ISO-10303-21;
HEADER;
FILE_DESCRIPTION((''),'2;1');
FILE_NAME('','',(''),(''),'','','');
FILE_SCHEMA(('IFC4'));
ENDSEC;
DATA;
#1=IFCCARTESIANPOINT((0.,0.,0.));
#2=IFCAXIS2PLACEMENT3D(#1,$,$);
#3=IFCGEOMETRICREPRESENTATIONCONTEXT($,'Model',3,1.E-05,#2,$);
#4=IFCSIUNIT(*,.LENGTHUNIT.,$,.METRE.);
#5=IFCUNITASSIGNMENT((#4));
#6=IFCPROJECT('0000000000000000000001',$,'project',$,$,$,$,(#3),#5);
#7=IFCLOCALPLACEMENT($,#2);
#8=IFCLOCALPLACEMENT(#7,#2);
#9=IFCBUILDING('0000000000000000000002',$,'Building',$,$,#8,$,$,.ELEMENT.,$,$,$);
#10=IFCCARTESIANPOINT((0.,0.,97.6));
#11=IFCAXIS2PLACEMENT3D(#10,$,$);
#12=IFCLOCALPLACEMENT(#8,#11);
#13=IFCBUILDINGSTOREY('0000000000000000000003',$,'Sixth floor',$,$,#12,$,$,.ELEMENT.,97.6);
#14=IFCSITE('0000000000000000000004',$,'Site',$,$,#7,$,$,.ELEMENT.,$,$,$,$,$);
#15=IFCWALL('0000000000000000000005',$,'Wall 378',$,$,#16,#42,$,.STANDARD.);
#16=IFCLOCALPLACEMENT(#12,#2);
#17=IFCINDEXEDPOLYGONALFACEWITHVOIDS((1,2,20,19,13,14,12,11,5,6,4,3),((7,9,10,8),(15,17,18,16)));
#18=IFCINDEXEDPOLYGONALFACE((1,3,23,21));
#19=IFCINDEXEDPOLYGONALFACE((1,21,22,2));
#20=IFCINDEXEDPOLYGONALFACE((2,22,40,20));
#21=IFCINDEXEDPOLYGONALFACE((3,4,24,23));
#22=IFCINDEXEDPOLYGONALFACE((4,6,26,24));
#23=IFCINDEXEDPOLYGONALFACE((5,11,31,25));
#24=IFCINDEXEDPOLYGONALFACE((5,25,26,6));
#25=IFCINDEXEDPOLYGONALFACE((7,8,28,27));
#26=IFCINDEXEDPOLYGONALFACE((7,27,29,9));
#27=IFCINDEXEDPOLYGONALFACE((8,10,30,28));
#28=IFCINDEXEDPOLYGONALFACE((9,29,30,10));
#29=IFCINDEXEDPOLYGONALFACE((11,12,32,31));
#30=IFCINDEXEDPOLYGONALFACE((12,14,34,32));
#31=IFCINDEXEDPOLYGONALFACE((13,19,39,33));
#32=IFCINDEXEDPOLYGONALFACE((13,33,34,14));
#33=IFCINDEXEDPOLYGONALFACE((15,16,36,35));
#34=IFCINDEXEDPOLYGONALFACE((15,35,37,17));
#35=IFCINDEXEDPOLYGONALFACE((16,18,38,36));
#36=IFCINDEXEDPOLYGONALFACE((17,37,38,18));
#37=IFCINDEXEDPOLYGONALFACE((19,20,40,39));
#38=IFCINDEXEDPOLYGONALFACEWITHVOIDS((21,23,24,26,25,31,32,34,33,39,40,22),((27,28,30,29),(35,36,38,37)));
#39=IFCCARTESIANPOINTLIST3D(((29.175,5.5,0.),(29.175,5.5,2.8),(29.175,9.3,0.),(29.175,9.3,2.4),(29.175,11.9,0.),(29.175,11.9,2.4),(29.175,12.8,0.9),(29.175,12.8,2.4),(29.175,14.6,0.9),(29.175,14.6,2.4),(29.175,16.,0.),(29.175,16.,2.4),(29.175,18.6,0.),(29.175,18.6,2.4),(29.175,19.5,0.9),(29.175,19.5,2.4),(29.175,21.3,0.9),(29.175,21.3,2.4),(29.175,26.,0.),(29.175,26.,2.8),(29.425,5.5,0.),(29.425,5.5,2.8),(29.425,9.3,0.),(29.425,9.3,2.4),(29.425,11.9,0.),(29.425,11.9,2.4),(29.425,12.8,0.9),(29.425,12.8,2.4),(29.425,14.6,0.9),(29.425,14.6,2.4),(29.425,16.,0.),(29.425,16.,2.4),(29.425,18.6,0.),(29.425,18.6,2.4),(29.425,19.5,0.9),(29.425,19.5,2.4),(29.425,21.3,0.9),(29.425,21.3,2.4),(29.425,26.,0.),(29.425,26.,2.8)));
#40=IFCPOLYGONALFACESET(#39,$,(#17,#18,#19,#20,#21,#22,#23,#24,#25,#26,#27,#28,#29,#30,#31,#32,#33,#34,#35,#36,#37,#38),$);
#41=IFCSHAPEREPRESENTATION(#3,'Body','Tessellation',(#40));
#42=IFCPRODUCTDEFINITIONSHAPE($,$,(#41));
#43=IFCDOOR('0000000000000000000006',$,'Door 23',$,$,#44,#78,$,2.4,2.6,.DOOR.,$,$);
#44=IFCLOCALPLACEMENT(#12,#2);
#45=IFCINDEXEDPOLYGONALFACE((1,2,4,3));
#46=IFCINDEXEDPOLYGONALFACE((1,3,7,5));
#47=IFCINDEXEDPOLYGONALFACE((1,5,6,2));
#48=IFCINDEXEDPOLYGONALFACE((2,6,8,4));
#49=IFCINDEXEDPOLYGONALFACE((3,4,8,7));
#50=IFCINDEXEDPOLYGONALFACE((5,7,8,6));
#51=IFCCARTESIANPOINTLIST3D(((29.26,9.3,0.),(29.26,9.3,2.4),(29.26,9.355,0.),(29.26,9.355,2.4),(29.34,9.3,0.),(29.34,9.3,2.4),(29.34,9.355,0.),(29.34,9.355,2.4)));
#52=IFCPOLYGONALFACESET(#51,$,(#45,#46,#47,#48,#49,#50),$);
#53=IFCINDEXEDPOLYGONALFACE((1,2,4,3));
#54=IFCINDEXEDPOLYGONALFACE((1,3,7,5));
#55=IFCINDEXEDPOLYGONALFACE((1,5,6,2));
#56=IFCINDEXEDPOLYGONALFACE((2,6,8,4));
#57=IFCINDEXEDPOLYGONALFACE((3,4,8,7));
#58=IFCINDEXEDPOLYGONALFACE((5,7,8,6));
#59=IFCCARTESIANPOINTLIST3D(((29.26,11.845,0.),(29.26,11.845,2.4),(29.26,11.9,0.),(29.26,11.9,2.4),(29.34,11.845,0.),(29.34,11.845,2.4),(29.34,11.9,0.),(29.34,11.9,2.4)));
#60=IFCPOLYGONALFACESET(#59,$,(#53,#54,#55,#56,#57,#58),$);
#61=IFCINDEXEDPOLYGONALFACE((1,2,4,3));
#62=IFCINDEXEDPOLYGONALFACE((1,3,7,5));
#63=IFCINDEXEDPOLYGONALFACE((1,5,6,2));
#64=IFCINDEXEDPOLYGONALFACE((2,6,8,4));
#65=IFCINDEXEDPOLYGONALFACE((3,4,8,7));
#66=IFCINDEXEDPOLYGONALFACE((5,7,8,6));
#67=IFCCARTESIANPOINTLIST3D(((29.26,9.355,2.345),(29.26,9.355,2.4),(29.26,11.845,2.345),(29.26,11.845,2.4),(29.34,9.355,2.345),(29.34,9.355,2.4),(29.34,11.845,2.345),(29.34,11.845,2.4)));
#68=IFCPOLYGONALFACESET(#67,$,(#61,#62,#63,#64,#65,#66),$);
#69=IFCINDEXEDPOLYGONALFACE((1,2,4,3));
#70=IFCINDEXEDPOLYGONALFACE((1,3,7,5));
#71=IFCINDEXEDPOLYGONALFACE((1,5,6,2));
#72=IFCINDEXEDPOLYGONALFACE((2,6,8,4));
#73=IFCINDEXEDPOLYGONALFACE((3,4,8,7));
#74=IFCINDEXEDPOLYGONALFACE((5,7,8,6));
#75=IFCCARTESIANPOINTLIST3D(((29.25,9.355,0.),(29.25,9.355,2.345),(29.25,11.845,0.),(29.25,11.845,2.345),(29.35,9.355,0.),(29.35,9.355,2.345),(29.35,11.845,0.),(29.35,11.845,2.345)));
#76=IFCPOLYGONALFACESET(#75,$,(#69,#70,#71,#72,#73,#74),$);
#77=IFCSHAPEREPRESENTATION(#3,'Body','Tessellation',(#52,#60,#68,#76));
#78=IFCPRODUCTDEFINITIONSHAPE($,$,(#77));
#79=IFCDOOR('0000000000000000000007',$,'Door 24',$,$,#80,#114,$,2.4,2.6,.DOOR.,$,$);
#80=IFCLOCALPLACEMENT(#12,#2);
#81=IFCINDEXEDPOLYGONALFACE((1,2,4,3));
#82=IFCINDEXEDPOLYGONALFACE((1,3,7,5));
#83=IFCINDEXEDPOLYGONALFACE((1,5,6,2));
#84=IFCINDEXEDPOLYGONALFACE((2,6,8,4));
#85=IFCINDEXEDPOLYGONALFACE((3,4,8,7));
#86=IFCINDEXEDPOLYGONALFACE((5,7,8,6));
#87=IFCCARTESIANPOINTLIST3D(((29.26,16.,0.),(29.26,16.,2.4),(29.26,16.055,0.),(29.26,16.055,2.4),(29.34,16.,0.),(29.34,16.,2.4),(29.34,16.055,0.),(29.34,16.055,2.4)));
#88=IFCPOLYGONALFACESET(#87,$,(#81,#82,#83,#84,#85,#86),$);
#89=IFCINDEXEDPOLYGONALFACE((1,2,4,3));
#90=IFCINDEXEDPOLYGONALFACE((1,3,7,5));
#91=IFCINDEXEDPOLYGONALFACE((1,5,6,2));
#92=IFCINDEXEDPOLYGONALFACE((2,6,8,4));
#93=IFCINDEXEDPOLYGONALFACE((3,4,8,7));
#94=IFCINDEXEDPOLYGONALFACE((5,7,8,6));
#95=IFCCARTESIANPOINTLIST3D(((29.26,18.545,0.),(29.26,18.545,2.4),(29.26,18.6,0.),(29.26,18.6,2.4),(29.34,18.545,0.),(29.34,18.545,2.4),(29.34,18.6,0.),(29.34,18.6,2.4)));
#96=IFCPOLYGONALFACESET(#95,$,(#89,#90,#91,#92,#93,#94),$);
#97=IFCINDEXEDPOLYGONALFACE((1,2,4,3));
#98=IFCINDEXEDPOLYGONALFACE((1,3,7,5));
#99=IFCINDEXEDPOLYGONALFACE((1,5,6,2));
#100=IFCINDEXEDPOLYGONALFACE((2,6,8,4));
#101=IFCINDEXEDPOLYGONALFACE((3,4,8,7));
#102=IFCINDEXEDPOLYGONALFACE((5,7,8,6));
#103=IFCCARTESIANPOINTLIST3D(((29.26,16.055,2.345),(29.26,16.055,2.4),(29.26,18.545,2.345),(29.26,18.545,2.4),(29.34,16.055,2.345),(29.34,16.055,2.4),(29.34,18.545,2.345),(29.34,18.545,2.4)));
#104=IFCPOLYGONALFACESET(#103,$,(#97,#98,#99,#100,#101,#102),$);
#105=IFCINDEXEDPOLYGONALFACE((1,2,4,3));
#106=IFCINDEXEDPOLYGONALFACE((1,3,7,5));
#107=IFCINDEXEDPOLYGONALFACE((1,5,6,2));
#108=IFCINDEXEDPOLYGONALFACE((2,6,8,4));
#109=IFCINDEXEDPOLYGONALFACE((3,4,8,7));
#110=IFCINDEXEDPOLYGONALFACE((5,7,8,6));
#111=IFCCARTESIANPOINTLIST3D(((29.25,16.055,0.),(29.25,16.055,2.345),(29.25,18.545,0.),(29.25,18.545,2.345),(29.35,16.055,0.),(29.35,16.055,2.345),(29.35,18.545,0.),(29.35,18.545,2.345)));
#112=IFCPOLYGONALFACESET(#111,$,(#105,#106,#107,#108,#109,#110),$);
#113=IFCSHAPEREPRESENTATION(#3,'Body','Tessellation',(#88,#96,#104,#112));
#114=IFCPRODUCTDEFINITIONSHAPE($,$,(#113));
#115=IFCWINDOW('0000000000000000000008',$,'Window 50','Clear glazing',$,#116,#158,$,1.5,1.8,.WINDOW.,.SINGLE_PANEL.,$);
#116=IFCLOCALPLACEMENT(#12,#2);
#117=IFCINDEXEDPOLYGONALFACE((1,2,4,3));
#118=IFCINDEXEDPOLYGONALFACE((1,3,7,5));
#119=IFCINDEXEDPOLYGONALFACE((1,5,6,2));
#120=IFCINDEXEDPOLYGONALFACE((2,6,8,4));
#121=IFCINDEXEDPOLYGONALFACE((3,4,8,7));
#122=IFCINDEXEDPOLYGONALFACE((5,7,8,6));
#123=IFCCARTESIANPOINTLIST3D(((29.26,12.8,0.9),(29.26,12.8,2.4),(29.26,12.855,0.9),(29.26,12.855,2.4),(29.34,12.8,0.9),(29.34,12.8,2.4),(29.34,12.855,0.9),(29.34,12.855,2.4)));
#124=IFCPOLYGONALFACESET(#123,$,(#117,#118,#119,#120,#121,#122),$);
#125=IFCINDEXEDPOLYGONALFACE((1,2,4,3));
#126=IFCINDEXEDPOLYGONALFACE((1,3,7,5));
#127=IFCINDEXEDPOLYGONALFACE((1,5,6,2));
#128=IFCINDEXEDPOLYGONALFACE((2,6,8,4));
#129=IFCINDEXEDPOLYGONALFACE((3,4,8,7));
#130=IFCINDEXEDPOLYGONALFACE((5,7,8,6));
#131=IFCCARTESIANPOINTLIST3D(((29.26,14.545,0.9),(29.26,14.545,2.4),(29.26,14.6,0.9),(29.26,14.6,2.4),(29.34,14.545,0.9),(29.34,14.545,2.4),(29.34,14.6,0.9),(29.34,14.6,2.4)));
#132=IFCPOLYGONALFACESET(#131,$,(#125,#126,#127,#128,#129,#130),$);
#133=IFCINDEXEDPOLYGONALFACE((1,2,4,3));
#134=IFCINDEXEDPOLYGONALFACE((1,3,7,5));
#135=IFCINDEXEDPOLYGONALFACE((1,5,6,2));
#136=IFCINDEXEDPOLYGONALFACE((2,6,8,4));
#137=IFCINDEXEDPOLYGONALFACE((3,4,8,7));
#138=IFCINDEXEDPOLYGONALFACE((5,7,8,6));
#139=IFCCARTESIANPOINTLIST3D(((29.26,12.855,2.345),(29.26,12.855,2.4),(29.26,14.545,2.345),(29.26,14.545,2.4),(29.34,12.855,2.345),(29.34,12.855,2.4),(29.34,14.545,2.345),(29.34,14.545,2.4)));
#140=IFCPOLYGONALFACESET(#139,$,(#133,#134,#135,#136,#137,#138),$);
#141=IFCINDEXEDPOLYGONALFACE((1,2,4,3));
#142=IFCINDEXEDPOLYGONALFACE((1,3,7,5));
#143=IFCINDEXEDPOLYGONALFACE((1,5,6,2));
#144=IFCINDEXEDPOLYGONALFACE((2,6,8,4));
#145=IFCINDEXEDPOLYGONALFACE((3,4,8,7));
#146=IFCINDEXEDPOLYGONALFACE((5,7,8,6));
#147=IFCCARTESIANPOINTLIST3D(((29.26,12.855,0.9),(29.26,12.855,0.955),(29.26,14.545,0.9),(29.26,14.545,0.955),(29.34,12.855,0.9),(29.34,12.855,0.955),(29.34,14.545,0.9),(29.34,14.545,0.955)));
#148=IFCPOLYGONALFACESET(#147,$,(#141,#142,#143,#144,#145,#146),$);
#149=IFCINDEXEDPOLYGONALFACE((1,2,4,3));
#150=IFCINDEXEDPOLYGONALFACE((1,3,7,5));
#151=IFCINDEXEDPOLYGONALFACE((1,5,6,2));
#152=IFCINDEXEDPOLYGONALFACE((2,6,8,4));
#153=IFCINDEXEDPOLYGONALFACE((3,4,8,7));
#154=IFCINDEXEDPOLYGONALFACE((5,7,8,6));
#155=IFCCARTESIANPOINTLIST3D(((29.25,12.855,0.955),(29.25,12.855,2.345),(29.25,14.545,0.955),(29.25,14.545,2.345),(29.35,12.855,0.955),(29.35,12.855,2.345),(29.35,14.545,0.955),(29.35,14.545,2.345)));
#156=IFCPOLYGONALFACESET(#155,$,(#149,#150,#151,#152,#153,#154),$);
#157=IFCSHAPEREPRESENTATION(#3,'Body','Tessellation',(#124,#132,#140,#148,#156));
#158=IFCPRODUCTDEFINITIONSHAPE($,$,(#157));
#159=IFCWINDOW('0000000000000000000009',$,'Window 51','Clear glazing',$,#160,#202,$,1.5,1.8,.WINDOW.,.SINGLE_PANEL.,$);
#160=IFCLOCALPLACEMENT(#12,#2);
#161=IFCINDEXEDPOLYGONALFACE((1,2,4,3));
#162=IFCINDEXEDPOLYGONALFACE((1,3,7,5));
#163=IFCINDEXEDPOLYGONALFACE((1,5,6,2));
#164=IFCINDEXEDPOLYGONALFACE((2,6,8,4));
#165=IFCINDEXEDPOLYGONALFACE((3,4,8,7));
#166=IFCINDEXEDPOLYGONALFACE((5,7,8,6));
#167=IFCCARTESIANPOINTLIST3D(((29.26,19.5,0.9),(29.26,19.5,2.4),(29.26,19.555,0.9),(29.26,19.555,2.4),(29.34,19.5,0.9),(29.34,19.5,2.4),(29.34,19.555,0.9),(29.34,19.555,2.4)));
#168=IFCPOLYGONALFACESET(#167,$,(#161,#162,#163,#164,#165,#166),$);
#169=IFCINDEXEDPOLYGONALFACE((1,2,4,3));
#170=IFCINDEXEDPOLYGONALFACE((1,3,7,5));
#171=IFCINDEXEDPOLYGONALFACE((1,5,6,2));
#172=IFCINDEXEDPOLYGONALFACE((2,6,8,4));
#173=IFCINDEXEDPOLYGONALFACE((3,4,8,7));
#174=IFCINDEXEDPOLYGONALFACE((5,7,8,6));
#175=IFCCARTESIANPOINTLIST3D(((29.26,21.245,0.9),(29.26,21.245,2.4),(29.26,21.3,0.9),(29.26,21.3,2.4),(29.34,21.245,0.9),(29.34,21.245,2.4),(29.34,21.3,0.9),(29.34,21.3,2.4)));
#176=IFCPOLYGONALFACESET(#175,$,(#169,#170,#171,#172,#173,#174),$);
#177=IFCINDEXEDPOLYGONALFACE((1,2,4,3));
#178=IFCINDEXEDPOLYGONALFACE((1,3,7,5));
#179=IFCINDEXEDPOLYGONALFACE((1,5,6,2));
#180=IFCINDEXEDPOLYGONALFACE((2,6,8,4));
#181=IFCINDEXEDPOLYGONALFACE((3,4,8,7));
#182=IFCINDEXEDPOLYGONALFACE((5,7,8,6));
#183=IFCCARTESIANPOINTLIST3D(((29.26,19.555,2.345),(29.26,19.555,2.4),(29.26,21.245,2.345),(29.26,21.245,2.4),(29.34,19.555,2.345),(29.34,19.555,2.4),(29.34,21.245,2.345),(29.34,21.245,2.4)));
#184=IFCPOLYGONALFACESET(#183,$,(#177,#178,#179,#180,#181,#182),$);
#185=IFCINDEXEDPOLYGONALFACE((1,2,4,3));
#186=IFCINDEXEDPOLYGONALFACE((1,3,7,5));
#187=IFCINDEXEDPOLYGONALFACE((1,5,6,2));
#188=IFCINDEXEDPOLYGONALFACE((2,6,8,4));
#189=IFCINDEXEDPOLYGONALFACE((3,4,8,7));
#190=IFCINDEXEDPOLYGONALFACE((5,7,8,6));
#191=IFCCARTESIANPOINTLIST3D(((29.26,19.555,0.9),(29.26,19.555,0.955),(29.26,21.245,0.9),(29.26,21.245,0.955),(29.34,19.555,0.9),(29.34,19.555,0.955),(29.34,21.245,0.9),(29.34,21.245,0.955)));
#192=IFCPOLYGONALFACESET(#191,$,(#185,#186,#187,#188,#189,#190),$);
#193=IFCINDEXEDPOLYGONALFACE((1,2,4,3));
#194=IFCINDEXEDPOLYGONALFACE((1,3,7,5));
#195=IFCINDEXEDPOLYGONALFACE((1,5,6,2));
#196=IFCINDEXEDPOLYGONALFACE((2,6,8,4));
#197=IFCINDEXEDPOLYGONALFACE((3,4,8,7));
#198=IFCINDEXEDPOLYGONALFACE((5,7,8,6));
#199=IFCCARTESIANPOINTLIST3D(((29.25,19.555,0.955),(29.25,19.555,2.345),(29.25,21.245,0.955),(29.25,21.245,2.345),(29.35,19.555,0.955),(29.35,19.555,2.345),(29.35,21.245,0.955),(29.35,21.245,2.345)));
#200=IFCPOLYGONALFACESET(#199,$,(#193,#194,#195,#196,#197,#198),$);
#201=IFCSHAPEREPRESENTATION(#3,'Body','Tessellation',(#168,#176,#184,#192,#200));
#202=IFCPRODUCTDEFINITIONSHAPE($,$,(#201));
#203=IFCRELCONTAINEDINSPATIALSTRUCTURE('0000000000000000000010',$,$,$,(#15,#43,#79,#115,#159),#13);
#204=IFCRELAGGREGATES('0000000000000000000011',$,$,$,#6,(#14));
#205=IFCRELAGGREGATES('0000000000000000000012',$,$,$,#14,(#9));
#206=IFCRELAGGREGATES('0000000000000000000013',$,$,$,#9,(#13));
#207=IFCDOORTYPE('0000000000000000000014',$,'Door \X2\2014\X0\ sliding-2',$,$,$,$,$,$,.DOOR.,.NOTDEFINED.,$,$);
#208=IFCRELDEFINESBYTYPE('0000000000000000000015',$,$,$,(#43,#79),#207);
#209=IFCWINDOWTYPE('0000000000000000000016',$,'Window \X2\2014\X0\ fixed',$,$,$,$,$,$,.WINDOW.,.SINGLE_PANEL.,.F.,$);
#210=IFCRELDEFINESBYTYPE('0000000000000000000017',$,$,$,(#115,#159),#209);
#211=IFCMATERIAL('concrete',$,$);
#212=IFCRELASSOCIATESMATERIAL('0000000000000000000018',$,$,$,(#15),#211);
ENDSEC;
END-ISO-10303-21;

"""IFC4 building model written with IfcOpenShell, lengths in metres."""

from ifc_helpers import new_model, si_unit, frame, frame_2d, origin, place, context, project, spatial, rectangle, extrude, material, type_object, element, fill, save


model = new_model("IFC4")

# Units and contexts
model_context = context("Model", 3, precision=1e-05, world=origin())
ifc_project = project(units=[si_unit("LENGTHUNIT", "METRE")], contexts=[model_context])

# Site, building, storey
site_placement = place(None, origin())
site = spatial("IfcSite", under=ifc_project, at=site_placement, Name="Site", CompositionType="ELEMENT")
building_placement = place(site_placement, origin())
building = spatial("IfcBuilding", under=site, at=building_placement, Name="Building", CompositionType="ELEMENT")
storey_placement = place(building_placement, frame((0.0, 0.0, 97.6)))
storey = spatial("IfcBuildingStorey", under=building, at=storey_placement, Name="Sixth floor", CompositionType="ELEMENT", Elevation=97.6)

# Shared definitions
ifc_material = material(Name="concrete")

# Wall, openings, doors, windows
wall_1_placement = place(storey_placement, frame((29.3, 5.5, 0.0), z_axis=(0.0, 0.0, 1.0), x_axis=(0.0, 1.0, 0.0)))
wall_1 = element("IfcWall", 1, at=wall_1_placement, inside=storey, material=ifc_material, Name="Wall 378", PredefinedType="STANDARD", context=model_context, shape_type="SweptSolid", body=[
    extrude(rectangle(XDim=20.5, YDim=0.25, at=frame_2d((10.25, 0.0))), origin(), (0.0, 0.0, 1.0), 2.8),
])
opening_1_placement = place(storey_placement, frame((29.3, 9.3, 0.0), z_axis=(0.0, 0.0, 1.0), x_axis=(0.0, 1.0, 0.0)))
opening_1 = element("IfcOpeningElement", 2, at=opening_1_placement, cuts=wall_1, PredefinedType="OPENING", context=model_context, shape_type="SweptSolid", body=[
    extrude(rectangle(XDim=2.6, YDim=0.31, at=frame_2d((1.3, 0.0))), origin(), (0.0, 0.0, 1.0), 2.4),
])
opening_2_placement = place(storey_placement, frame((29.3, 12.8, 0.9), z_axis=(0.0, 0.0, 1.0), x_axis=(0.0, 1.0, 0.0)))
opening_2 = element("IfcOpeningElement", 3, at=opening_2_placement, cuts=wall_1, PredefinedType="OPENING", context=model_context, shape_type="SweptSolid", body=[
    extrude(rectangle(XDim=1.8, YDim=0.31, at=frame_2d((0.9, 0.0))), origin(), (0.0, 0.0, 1.0), 1.5),
])
opening_3_placement = place(storey_placement, frame((29.3, 16.0, 0.0), z_axis=(0.0, 0.0, 1.0), x_axis=(0.0, 1.0, 0.0)))
opening_3 = element("IfcOpeningElement", 4, at=opening_3_placement, cuts=wall_1, PredefinedType="OPENING", context=model_context, shape_type="SweptSolid", body=[
    extrude(rectangle(XDim=2.6, YDim=0.31, at=frame_2d((1.3, 0.0))), origin(), (0.0, 0.0, 1.0), 2.4),
])
opening_4_placement = place(storey_placement, frame((29.3, 19.5, 0.9), z_axis=(0.0, 0.0, 1.0), x_axis=(0.0, 1.0, 0.0)))
opening_4 = element("IfcOpeningElement", 5, at=opening_4_placement, cuts=wall_1, PredefinedType="OPENING", context=model_context, shape_type="SweptSolid", body=[
    extrude(rectangle(XDim=1.8, YDim=0.31, at=frame_2d((0.9, 0.0))), origin(), (0.0, 0.0, 1.0), 1.5),
])
door_type = type_object("IfcDoorType", Name="Door — sliding-2", PredefinedType="DOOR")
door_1_placement = place(storey_placement, frame((29.3, 9.3, 0.0), z_axis=(0.0, 0.0, 1.0), x_axis=(0.0, 1.0, 0.0)))
door_1 = element("IfcDoor", 6, at=door_1_placement, inside=storey, type_object=door_type, Name="Door 23", OverallHeight=2.4, OverallWidth=2.6, PredefinedType="DOOR", context=model_context, shape_type="SweptSolid", body=[
    extrude(rectangle(XDim=0.055, YDim=0.08, at=frame_2d((0.0275, 0.0))), origin(), (0.0, 0.0, 1.0), 2.4),
    extrude(rectangle(XDim=0.055, YDim=0.08, at=frame_2d((2.5725, 0.0))), origin(), (0.0, 0.0, 1.0), 2.4),
    extrude(rectangle(XDim=2.49, YDim=0.08, at=frame_2d((1.3, 0.0))), frame((0.0, 0.0, 2.345)), (0.0, 0.0, 1.0), 0.055),
    extrude(rectangle(XDim=2.49, YDim=0.1, at=frame_2d((1.3, 0.0))), origin(), (0.0, 0.0, 1.0), 2.345),
])
fill(opening_1, door_1)
door_2_placement = place(storey_placement, frame((29.3, 16.0, 0.0), z_axis=(0.0, 0.0, 1.0), x_axis=(0.0, 1.0, 0.0)))
door_2 = element("IfcDoor", 7, at=door_2_placement, inside=storey, type_object=door_type, Name="Door 24", OverallHeight=2.4, OverallWidth=2.6, PredefinedType="DOOR", context=model_context, shape_type="SweptSolid", body=[
    extrude(rectangle(XDim=0.055, YDim=0.08, at=frame_2d((0.0275, 0.0))), origin(), (0.0, 0.0, 1.0), 2.4),
    extrude(rectangle(XDim=0.055, YDim=0.08, at=frame_2d((2.5725, 0.0))), origin(), (0.0, 0.0, 1.0), 2.4),
    extrude(rectangle(XDim=2.49, YDim=0.08, at=frame_2d((1.3, 0.0))), frame((0.0, 0.0, 2.345)), (0.0, 0.0, 1.0), 0.055),
    extrude(rectangle(XDim=2.49, YDim=0.1, at=frame_2d((1.3, 0.0))), origin(), (0.0, 0.0, 1.0), 2.345),
])
fill(opening_3, door_2)
window_type = type_object("IfcWindowType", Name="Window — fixed", ParameterTakesPrecedence=False, PartitioningType="SINGLE_PANEL", PredefinedType="WINDOW")
window_1_placement = place(storey_placement, frame((29.3, 12.8, 0.9), z_axis=(0.0, 0.0, 1.0), x_axis=(0.0, 1.0, 0.0)))
window_1 = element("IfcWindow", 8, at=window_1_placement, inside=storey, type_object=window_type, Name="Window 50", Description="Clear glazing", OverallHeight=1.5, OverallWidth=1.8, PartitioningType="SINGLE_PANEL", PredefinedType="WINDOW", context=model_context, shape_type="SweptSolid", body=[
    extrude(rectangle(XDim=0.055, YDim=0.08, at=frame_2d((0.0275, 0.0))), origin(), (0.0, 0.0, 1.0), 1.5),
    extrude(rectangle(XDim=0.055, YDim=0.08, at=frame_2d((1.7725, 0.0))), origin(), (0.0, 0.0, 1.0), 1.5),
    extrude(rectangle(XDim=1.69, YDim=0.08, at=frame_2d((0.9, 0.0))), frame((0.0, 0.0, 1.445)), (0.0, 0.0, 1.0), 0.055),
    extrude(rectangle(XDim=1.69, YDim=0.08, at=frame_2d((0.9, 0.0))), origin(), (0.0, 0.0, 1.0), 0.055),
    extrude(rectangle(XDim=1.69, YDim=0.1, at=frame_2d((0.9, 0.0))), frame((0.0, 0.0, 0.055)), (0.0, 0.0, 1.0), 1.39),
])
fill(opening_2, window_1)
window_2_placement = place(storey_placement, frame((29.3, 19.5, 0.9), z_axis=(0.0, 0.0, 1.0), x_axis=(0.0, 1.0, 0.0)))
window_2 = element("IfcWindow", 9, at=window_2_placement, inside=storey, type_object=window_type, Name="Window 51", Description="Clear glazing", OverallHeight=1.5, OverallWidth=1.8, PartitioningType="SINGLE_PANEL", PredefinedType="WINDOW", context=model_context, shape_type="SweptSolid", body=[
    extrude(rectangle(XDim=0.055, YDim=0.08, at=frame_2d((0.0275, 0.0))), origin(), (0.0, 0.0, 1.0), 1.5),
    extrude(rectangle(XDim=0.055, YDim=0.08, at=frame_2d((1.7725, 0.0))), origin(), (0.0, 0.0, 1.0), 1.5),
    extrude(rectangle(XDim=1.69, YDim=0.08, at=frame_2d((0.9, 0.0))), frame((0.0, 0.0, 1.445)), (0.0, 0.0, 1.0), 0.055),
    extrude(rectangle(XDim=1.69, YDim=0.08, at=frame_2d((0.9, 0.0))), origin(), (0.0, 0.0, 1.0), 0.055),
    extrude(rectangle(XDim=1.69, YDim=0.1, at=frame_2d((0.9, 0.0))), frame((0.0, 0.0, 0.055)), (0.0, 0.0, 1.0), 1.39),
])
fill(opening_4, window_2)

save(model, "model.ifc")
